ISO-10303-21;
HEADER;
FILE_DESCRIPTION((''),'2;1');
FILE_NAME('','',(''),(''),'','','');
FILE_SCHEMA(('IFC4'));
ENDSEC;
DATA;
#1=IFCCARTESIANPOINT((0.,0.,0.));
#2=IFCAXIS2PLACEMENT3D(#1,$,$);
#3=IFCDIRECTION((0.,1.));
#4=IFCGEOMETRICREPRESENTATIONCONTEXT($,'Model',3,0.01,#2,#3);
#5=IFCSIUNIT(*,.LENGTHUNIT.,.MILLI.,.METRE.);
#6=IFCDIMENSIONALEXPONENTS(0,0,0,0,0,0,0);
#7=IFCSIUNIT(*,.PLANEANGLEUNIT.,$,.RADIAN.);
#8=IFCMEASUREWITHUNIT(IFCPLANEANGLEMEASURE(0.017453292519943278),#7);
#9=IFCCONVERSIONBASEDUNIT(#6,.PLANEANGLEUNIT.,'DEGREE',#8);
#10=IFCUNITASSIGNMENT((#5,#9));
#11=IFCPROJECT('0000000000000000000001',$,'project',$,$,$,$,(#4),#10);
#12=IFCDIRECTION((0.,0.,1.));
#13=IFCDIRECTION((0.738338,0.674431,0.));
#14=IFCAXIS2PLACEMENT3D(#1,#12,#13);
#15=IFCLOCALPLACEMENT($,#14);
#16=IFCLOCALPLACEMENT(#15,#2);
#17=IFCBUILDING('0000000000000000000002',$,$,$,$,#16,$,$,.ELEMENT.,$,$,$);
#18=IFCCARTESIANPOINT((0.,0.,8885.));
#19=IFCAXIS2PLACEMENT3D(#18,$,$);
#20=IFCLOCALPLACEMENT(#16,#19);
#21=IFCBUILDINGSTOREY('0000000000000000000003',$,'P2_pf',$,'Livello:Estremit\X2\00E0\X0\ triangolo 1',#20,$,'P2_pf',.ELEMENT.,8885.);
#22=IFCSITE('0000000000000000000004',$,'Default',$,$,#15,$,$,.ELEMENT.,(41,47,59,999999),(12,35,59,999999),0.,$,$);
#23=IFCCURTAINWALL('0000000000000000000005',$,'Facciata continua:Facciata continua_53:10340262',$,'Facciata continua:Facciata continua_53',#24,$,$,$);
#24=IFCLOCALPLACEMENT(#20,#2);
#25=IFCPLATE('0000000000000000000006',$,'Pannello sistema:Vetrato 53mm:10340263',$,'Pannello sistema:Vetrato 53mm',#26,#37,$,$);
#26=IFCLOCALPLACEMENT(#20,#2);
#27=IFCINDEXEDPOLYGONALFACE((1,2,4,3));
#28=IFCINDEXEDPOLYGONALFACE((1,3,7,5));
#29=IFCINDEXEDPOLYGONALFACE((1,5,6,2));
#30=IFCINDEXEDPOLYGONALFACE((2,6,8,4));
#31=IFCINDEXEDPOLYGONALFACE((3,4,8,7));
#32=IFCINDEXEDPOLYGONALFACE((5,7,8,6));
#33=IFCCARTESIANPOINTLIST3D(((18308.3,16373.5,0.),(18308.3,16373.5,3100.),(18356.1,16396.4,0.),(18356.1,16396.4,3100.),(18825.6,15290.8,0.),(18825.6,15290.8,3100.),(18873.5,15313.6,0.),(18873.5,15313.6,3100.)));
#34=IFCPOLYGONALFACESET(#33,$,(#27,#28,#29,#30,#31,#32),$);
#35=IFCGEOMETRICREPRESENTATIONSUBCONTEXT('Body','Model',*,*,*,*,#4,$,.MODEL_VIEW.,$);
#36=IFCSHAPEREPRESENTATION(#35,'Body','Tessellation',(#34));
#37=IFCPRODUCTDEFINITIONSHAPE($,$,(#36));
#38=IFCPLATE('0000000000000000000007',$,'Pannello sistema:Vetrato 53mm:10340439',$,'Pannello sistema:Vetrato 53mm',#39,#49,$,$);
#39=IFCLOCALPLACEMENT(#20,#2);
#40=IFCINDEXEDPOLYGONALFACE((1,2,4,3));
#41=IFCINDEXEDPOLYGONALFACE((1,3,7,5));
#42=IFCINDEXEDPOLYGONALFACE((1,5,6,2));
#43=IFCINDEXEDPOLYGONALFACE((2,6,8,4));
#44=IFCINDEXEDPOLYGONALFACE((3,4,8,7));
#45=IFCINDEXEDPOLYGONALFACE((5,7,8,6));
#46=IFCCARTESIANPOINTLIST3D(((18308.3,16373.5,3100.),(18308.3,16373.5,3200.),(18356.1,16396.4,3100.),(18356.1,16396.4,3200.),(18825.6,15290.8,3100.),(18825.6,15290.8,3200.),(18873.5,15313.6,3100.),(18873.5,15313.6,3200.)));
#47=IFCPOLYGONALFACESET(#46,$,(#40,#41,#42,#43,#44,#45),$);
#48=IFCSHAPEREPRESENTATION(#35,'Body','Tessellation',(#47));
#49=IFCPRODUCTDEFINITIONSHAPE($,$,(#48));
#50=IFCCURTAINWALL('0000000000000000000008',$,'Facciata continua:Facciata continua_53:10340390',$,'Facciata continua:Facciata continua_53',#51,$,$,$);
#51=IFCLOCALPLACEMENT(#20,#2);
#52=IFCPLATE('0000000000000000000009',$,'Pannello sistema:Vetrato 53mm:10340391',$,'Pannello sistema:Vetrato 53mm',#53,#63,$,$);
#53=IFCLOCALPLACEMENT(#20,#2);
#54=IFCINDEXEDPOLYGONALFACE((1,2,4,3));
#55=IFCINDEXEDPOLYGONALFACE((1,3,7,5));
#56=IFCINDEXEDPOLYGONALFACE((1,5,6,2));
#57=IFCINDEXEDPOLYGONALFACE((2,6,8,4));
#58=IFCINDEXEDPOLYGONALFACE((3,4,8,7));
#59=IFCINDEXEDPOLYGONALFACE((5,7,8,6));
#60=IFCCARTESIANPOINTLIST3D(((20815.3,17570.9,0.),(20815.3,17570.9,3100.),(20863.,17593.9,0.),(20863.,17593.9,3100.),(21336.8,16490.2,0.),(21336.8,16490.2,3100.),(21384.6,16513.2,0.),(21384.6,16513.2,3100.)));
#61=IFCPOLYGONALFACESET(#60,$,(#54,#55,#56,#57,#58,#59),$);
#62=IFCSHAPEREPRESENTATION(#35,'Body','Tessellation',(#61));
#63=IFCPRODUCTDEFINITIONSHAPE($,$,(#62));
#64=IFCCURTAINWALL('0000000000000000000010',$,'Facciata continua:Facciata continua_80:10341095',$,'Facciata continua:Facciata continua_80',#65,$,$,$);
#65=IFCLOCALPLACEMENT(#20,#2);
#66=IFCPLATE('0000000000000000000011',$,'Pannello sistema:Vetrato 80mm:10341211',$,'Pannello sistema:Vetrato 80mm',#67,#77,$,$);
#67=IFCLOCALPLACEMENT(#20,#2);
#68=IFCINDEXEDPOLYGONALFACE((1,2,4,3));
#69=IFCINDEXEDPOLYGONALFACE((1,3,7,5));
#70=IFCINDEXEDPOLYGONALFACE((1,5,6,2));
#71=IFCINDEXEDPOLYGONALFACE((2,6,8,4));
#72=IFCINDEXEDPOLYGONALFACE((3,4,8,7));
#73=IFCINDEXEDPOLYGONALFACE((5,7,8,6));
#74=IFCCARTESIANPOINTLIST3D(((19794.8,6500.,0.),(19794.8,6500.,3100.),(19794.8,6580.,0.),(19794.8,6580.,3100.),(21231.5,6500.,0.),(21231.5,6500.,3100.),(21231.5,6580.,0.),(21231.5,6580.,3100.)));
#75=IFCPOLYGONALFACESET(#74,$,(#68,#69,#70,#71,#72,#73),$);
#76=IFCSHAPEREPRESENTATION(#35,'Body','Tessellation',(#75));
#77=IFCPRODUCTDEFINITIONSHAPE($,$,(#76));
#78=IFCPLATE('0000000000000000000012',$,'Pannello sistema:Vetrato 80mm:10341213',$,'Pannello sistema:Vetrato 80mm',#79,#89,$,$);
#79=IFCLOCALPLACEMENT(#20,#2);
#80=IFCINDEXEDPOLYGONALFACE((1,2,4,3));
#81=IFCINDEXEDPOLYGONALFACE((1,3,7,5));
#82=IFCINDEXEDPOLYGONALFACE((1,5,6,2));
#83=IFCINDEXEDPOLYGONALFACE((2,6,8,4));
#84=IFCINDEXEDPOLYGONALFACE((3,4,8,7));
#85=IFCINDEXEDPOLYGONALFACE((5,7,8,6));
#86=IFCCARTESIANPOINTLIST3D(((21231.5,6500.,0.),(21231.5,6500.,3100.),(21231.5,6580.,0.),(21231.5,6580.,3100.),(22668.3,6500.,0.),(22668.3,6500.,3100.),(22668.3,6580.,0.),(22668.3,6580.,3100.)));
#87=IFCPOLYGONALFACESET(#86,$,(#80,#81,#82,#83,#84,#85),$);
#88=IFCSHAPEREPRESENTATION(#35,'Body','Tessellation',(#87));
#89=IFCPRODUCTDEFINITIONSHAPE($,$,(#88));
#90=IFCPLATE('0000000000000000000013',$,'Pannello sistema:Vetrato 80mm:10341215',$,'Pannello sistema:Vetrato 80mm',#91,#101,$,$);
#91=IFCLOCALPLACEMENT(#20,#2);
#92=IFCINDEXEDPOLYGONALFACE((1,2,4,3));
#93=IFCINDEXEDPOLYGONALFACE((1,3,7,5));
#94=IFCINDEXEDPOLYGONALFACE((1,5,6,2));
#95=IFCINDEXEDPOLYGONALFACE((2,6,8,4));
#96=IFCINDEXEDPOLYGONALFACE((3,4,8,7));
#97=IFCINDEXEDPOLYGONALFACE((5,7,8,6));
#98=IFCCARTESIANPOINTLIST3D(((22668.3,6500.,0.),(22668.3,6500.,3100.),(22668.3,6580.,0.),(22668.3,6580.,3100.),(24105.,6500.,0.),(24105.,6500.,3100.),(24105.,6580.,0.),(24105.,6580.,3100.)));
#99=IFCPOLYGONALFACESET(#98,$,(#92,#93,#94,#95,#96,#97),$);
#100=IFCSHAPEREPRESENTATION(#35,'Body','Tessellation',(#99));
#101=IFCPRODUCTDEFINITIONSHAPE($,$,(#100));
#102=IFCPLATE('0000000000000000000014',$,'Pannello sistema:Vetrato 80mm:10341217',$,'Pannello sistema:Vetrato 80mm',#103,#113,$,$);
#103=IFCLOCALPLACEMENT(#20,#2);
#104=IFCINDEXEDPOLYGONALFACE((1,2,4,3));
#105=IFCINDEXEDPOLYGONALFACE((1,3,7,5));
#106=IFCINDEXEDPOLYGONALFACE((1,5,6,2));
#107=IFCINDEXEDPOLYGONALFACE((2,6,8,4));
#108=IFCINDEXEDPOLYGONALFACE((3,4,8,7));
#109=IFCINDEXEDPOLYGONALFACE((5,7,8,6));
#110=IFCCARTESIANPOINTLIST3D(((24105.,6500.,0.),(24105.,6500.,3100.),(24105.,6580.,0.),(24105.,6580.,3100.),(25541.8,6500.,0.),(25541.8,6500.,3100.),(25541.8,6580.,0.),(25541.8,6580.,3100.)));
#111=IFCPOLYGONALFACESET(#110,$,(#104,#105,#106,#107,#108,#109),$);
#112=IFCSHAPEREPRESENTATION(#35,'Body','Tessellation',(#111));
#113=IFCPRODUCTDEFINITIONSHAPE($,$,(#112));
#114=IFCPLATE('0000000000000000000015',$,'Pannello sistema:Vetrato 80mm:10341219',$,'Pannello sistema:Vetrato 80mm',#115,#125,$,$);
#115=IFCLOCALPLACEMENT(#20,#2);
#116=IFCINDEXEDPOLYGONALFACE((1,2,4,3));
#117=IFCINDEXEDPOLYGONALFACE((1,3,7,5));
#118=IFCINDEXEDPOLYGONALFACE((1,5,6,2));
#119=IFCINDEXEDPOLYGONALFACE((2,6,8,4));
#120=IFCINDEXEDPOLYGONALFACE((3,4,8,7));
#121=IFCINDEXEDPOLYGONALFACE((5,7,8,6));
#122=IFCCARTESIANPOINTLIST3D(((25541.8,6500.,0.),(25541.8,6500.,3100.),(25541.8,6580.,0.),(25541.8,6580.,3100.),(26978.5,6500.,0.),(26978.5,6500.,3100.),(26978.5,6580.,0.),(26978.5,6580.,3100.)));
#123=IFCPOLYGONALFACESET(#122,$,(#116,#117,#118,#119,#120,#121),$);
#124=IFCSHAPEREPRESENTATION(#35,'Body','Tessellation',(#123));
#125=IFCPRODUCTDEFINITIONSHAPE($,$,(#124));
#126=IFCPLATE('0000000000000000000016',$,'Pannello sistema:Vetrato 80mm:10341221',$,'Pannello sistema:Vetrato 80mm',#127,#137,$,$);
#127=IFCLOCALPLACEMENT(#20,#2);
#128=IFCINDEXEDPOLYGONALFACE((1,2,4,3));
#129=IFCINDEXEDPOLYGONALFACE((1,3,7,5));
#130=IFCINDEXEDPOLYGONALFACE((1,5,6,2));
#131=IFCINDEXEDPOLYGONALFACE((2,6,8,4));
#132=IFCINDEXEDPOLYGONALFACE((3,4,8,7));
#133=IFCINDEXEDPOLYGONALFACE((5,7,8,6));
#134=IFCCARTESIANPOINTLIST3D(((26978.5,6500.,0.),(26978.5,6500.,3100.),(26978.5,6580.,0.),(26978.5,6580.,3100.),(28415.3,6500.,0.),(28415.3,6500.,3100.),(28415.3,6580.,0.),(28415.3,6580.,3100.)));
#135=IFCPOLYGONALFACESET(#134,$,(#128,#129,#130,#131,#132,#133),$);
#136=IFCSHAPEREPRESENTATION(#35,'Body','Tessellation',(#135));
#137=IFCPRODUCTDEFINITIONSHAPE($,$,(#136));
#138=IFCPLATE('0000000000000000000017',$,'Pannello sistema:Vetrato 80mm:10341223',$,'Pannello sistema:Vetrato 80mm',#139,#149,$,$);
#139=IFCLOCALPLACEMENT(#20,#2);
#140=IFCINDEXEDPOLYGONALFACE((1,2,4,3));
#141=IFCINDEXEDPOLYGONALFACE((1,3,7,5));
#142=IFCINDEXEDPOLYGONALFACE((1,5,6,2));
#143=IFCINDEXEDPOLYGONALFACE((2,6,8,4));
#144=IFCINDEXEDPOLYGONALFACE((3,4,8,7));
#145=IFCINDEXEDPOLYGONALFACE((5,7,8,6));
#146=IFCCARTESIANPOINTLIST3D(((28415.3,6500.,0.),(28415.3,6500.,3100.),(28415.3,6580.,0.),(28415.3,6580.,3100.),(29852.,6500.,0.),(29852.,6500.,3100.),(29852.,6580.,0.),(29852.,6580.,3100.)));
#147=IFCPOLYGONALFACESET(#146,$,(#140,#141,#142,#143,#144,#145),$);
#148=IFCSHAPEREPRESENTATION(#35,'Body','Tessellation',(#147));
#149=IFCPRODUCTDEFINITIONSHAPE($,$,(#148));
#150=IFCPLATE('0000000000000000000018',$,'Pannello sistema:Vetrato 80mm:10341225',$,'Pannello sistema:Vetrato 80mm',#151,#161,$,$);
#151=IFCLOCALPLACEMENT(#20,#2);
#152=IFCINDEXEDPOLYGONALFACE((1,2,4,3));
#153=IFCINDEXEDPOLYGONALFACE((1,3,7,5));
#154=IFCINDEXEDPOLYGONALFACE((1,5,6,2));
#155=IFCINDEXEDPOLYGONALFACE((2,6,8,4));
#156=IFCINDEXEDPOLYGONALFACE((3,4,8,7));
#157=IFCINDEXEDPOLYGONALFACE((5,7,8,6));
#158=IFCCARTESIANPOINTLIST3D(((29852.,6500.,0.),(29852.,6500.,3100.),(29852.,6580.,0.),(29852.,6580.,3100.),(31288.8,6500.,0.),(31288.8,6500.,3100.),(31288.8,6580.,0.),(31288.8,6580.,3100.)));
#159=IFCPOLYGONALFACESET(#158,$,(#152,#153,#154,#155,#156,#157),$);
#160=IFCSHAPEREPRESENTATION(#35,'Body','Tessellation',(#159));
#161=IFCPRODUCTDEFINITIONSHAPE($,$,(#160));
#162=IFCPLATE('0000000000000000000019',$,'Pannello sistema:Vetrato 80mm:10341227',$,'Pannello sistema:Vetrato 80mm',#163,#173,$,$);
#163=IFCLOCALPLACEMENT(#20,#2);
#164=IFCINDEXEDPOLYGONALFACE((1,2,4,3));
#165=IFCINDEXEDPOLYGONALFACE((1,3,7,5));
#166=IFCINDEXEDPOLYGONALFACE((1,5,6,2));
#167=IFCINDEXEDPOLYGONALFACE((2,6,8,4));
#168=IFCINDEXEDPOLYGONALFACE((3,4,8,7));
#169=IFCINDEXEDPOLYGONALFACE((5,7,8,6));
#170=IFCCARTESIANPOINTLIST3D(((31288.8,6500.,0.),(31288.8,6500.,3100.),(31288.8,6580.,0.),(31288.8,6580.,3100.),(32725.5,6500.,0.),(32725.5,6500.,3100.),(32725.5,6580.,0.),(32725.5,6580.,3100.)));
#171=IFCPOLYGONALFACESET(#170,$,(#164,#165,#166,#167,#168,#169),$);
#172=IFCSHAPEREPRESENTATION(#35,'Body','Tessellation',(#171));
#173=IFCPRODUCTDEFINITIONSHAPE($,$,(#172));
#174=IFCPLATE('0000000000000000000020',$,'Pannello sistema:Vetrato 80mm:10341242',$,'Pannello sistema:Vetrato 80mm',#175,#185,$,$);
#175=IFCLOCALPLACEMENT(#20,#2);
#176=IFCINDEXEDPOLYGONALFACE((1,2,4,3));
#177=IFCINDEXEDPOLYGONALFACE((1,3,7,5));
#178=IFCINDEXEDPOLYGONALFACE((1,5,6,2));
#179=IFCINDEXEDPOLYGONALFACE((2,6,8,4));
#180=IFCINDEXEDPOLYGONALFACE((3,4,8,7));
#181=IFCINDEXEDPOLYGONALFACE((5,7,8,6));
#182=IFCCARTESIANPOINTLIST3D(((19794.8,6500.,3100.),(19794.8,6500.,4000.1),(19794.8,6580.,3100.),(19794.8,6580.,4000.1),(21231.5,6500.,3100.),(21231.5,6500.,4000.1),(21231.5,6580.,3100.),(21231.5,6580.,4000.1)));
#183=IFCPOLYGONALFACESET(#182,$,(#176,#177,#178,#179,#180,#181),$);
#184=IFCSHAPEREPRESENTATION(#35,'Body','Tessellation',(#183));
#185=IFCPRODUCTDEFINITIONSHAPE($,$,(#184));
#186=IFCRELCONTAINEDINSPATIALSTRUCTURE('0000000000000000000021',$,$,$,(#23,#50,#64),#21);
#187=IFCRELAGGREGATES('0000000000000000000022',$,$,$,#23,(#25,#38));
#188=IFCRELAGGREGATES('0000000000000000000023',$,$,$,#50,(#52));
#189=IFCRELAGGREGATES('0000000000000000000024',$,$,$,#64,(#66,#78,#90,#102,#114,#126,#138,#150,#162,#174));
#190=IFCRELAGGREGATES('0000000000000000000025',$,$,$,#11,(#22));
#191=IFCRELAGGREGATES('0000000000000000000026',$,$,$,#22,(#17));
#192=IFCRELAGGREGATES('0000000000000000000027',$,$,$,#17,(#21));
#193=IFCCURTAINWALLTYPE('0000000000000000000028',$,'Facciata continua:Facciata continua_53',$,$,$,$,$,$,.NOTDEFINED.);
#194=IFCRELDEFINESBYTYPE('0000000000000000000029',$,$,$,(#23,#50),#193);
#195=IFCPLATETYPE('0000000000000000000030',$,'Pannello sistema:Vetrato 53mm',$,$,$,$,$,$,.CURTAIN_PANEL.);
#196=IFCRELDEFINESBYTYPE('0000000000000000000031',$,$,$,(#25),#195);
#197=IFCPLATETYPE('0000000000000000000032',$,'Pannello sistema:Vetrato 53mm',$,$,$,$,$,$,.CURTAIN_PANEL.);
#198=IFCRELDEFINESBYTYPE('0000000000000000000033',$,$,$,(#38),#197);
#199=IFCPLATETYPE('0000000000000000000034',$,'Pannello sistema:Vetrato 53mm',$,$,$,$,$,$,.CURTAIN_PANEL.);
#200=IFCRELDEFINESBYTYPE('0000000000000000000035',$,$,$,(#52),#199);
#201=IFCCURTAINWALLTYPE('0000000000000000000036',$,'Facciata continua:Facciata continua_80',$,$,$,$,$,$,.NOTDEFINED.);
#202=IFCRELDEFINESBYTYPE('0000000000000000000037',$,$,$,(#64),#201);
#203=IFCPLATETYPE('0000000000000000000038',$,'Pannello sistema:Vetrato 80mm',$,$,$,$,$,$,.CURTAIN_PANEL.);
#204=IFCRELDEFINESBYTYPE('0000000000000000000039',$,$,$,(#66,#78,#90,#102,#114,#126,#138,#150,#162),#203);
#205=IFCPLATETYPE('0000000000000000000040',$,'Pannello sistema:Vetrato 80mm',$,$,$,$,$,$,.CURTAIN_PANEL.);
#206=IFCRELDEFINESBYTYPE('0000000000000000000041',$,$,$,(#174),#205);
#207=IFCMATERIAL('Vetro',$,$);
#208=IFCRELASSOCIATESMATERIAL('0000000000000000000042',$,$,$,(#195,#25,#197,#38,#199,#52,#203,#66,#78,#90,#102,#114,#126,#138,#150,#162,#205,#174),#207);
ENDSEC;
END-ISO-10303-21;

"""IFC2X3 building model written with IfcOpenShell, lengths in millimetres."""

from ifc_helpers import new_model, entity, si_unit, converted_unit, direction, frame, frame_2d, origin, origin_2d_with_axis, place, context, subcontext, project, spatial, rectangle, extrude, source, transform, mapped, material, type_object, type_shapes, element, aggregate, save


model = new_model("IFC2X3")

# Units and contexts
model_context = context("Model", 3, precision=0.01, world=origin(), true_north=direction((0.0, 1.0)))
body_context = subcontext(model_context, "Body", "Model", "MODEL_VIEW")
ifc_project = project(units=[si_unit("LENGTHUNIT", "METRE", prefix="MILLI"), converted_unit("PLANEANGLEUNIT", "DEGREE", entity("IfcPlaneAngleMeasure", 0.017453292519943278), si_unit("PLANEANGLEUNIT", "RADIAN"), dimensions=[0, 0, 0, 0, 0, 0, 0])], contexts=[model_context])

# Site, building, storey
site_placement = place(None, frame((0.0, 0.0, 0.0), z_axis=(0.0, 0.0, 1.0), x_axis=(0.738338, 0.674431, 0.0)))
site = spatial("IfcSite", under=ifc_project, at=site_placement, Name="Default", CompositionType="ELEMENT", RefLatitude=(41, 47, 59, 999999), RefLongitude=(12, 35, 59, 999999), RefElevation=0.0)
building_placement = place(site_placement, origin())
building = spatial("IfcBuilding", under=site, at=building_placement, CompositionType="ELEMENT")
storey_placement = place(building_placement, frame((0.0, 0.0, 8885.0)))
storey = spatial("IfcBuildingStorey", under=building, at=storey_placement, Name="P2_pf", ObjectType="Livello:Estremità triangolo 1", LongName="P2_pf", CompositionType="ELEMENT", Elevation=8885.0)

# Curtain wall, plates
curtain_wall_type_1 = type_object("IfcCurtainWallType", Name="Facciata continua:Facciata continua_53", PredefinedType="NOTDEFINED")
curtain_wall_1_placement = place(storey_placement, frame((0.0, 0.0, -8885.0)))
curtain_wall_1 = element("IfcCurtainWall", 1, at=curtain_wall_1_placement, inside=storey, type_object=curtain_wall_type_1, Name="Facciata continua:Facciata continua_53:10340262", ObjectType="Facciata continua:Facciata continua_53")
ifc_material_1 = material(Name="Vetro")
plate_type_1 = type_object("IfcPlateType", Name="Pannello sistema:Vetrato 53mm", PredefinedType="CURTAIN_PANEL", material=ifc_material_1)
shared_shape_1 = source(origin(), body_context, "Body", "SweptSolid", [
    extrude(rectangle(XDim=53.0, YDim=1200.0, at=frame_2d((0.0, 0.0), x_axis=(1.0, 0.0))), frame((0.0, -26.5, 0.0), z_axis=(0.0, 0.0, 1.0), x_axis=(0.0, 1.0, 0.0)), (0.0, 0.0, 1.0), 3100.0),
])
type_shapes(plate_type_1, [shared_shape_1])
plate_1_placement = place(curtain_wall_1_placement, frame((18567.0, 15832.1, 8885.0), z_axis=(0.0, 0.0, 1.0), x_axis=(-0.431118, 0.902296, 0.0)))
plate_1 = element("IfcPlate", 2, at=plate_1_placement, type_object=plate_type_1, material=ifc_material_1, Name="Pannello sistema:Vetrato 53mm:10340263", ObjectType="Pannello sistema:Vetrato 53mm", context=body_context, shape_type="MappedRepresentation", body=[
    mapped(shared_shape_1, transform((0.0, 0.0, 0.0), scale=1.0)),
])
plate_type_2 = type_object("IfcPlateType", Name="Pannello sistema:Vetrato 53mm", PredefinedType="CURTAIN_PANEL", material=ifc_material_1)
shared_shape_2 = source(origin(), body_context, "Body", "SweptSolid", [
    extrude(rectangle(XDim=53.0, YDim=1200.0, at=frame_2d((0.0, 0.0), x_axis=(1.0, 0.0))), frame((0.0, -26.5, 0.0), z_axis=(0.0, 0.0, 1.0), x_axis=(0.0, 1.0, 0.0)), (0.0, 0.0, 1.0), 100.0),
])
type_shapes(plate_type_2, [shared_shape_2])
plate_2_placement = place(curtain_wall_1_placement, frame((18567.0, 15832.1, 11985.0), z_axis=(0.0, 0.0, 1.0), x_axis=(-0.431118, 0.902296, 0.0)))
plate_2 = element("IfcPlate", 3, at=plate_2_placement, type_object=plate_type_2, material=ifc_material_1, Name="Pannello sistema:Vetrato 53mm:10340439", ObjectType="Pannello sistema:Vetrato 53mm", context=body_context, shape_type="MappedRepresentation", body=[
    mapped(shared_shape_2, transform((0.0, 0.0, 0.0), scale=1.0)),
])
aggregate(curtain_wall_1, [plate_1, plate_2])

# Curtain wall, plate
curtain_wall_2_placement = place(storey_placement, frame((0.0, 0.0, -8885.0)))
curtain_wall_2 = element("IfcCurtainWall", 4, at=curtain_wall_2_placement, inside=storey, type_object=curtain_wall_type_1, Name="Facciata continua:Facciata continua_53:10340390", ObjectType="Facciata continua:Facciata continua_53")
plate_type_3 = type_object("IfcPlateType", Name="Pannello sistema:Vetrato 53mm", PredefinedType="CURTAIN_PANEL", material=ifc_material_1)
shared_shape_3 = source(origin(), body_context, "Body", "SweptSolid", [
    extrude(rectangle(XDim=53.0, YDim=1200.0, at=frame_2d((0.0, 0.0), x_axis=(1.0, 0.0))), frame((0.0, -26.5, 0.0), z_axis=(0.0, 0.0, 1.0), x_axis=(0.0, 1.0, 0.0)), (0.0, 0.0, 1.0), 3100.0),
])
type_shapes(plate_type_3, [shared_shape_3])
plate_3_placement = place(curtain_wall_2_placement, frame((21076.1, 17030.5, 8885.0), z_axis=(0.0, 0.0, 1.0), x_axis=(-0.434619, 0.900614, 0.0)))
plate_3 = element("IfcPlate", 5, at=plate_3_placement, type_object=plate_type_3, material=ifc_material_1, Name="Pannello sistema:Vetrato 53mm:10340391", ObjectType="Pannello sistema:Vetrato 53mm", context=body_context, shape_type="MappedRepresentation", body=[
    mapped(shared_shape_3, transform((0.0, 0.0, 0.0), scale=1.0)),
])
aggregate(curtain_wall_2, [plate_3])

# Curtain wall, plates
curtain_wall_type_2 = type_object("IfcCurtainWallType", Name="Facciata continua:Facciata continua_80", PredefinedType="NOTDEFINED")
curtain_wall_3_placement = place(storey_placement, frame((0.0, 0.0, -8885.0)))
curtain_wall_3 = element("IfcCurtainWall", 6, at=curtain_wall_3_placement, inside=storey, type_object=curtain_wall_type_2, Name="Facciata continua:Facciata continua_80:10341095", ObjectType="Facciata continua:Facciata continua_80")
plate_type_4 = type_object("IfcPlateType", Name="Pannello sistema:Vetrato 80mm", PredefinedType="CURTAIN_PANEL", material=ifc_material_1)
shared_shape_4 = source(origin(), body_context, "Body", "SweptSolid", [
    extrude(rectangle(XDim=80.0, YDim=1436.8, at=origin_2d_with_axis()), frame((0.0, -40.0, 0.0), z_axis=(0.0, 0.0, 1.0), x_axis=(0.0, 1.0, 0.0)), (0.0, 0.0, 1.0), 3100.0),
])
type_shapes(plate_type_4, [shared_shape_4])
plate_4_placement = place(curtain_wall_3_placement, frame((20513.1, 6580.0, 8885.0)))
plate_4 = element("IfcPlate", 7, at=plate_4_placement, type_object=plate_type_4, material=ifc_material_1, Name="Pannello sistema:Vetrato 80mm:10341211", ObjectType="Pannello sistema:Vetrato 80mm", context=body_context, shape_type="MappedRepresentation", body=[
    mapped(shared_shape_4, transform((0.0, 0.0, 0.0), scale=1.0)),
])
plate_5_placement = place(curtain_wall_3_placement, frame((21949.9, 6580.0, 8885.0)))
plate_5 = element("IfcPlate", 8, at=plate_5_placement, type_object=plate_type_4, material=ifc_material_1, Name="Pannello sistema:Vetrato 80mm:10341213", ObjectType="Pannello sistema:Vetrato 80mm", context=body_context, shape_type="MappedRepresentation", body=[
    mapped(shared_shape_4, transform((0.0, 0.0, 0.0), scale=1.0)),
])
plate_6_placement = place(curtain_wall_3_placement, frame((23386.6, 6580.0, 8885.0)))
plate_6 = element("IfcPlate", 9, at=plate_6_placement, type_object=plate_type_4, material=ifc_material_1, Name="Pannello sistema:Vetrato 80mm:10341215", ObjectType="Pannello sistema:Vetrato 80mm", context=body_context, shape_type="MappedRepresentation", body=[
    mapped(shared_shape_4, transform((0.0, 0.0, 0.0), scale=1.0)),
])
plate_7_placement = place(curtain_wall_3_placement, frame((24823.4, 6580.0, 8885.0)))
plate_7 = element("IfcPlate", 10, at=plate_7_placement, type_object=plate_type_4, material=ifc_material_1, Name="Pannello sistema:Vetrato 80mm:10341217", ObjectType="Pannello sistema:Vetrato 80mm", context=body_context, shape_type="MappedRepresentation", body=[
    mapped(shared_shape_4, transform((0.0, 0.0, 0.0), scale=1.0)),
])
plate_8_placement = place(curtain_wall_3_placement, frame((26260.2, 6580.0, 8885.0)))
plate_8 = element("IfcPlate", 11, at=plate_8_placement, type_object=plate_type_4, material=ifc_material_1, Name="Pannello sistema:Vetrato 80mm:10341219", ObjectType="Pannello sistema:Vetrato 80mm", context=body_context, shape_type="MappedRepresentation", body=[
    mapped(shared_shape_4, transform((0.0, 0.0, 0.0), scale=1.0)),
])
plate_9_placement = place(curtain_wall_3_placement, frame((27696.9, 6580.0, 8885.0)))
plate_9 = element("IfcPlate", 12, at=plate_9_placement, type_object=plate_type_4, material=ifc_material_1, Name="Pannello sistema:Vetrato 80mm:10341221", ObjectType="Pannello sistema:Vetrato 80mm", context=body_context, shape_type="MappedRepresentation", body=[
    mapped(shared_shape_4, transform((0.0, 0.0, 0.0), scale=1.0)),
])
plate_10_placement = place(curtain_wall_3_placement, frame((29133.7, 6580.0, 8885.0)))
plate_10 = element("IfcPlate", 13, at=plate_10_placement, type_object=plate_type_4, material=ifc_material_1, Name="Pannello sistema:Vetrato 80mm:10341223", ObjectType="Pannello sistema:Vetrato 80mm", context=body_context, shape_type="MappedRepresentation", body=[
    mapped(shared_shape_4, transform((0.0, 0.0, 0.0), scale=1.0)),
])
plate_11_placement = place(curtain_wall_3_placement, frame((30570.4, 6580.0, 8885.0)))
plate_11 = element("IfcPlate", 14, at=plate_11_placement, type_object=plate_type_4, material=ifc_material_1, Name="Pannello sistema:Vetrato 80mm:10341225", ObjectType="Pannello sistema:Vetrato 80mm", context=body_context, shape_type="MappedRepresentation", body=[
    mapped(shared_shape_4, transform((0.0, 0.0, 0.0), scale=1.0)),
])
plate_12_placement = place(curtain_wall_3_placement, frame((32007.2, 6580.0, 8885.0)))
plate_12 = element("IfcPlate", 15, at=plate_12_placement, type_object=plate_type_4, material=ifc_material_1, Name="Pannello sistema:Vetrato 80mm:10341227", ObjectType="Pannello sistema:Vetrato 80mm", context=body_context, shape_type="MappedRepresentation", body=[
    mapped(shared_shape_4, transform((0.0, 0.0, 0.0), scale=1.0)),
])
plate_type_5 = type_object("IfcPlateType", Name="Pannello sistema:Vetrato 80mm", PredefinedType="CURTAIN_PANEL", material=ifc_material_1)
shared_shape_5 = source(origin(), body_context, "Body", "SweptSolid", [
    extrude(rectangle(XDim=80.0, YDim=1436.8, at=origin_2d_with_axis()), frame((0.0, -40.0, 0.0), z_axis=(0.0, 0.0, 1.0), x_axis=(0.0, 1.0, 0.0)), (0.0, 0.0, 1.0), 900.1),
])
type_shapes(plate_type_5, [shared_shape_5])
plate_13_placement = place(curtain_wall_3_placement, frame((20513.1, 6580.0, 11985.0)))
plate_13 = element("IfcPlate", 16, at=plate_13_placement, type_object=plate_type_5, material=ifc_material_1, Name="Pannello sistema:Vetrato 80mm:10341242", ObjectType="Pannello sistema:Vetrato 80mm", context=body_context, shape_type="MappedRepresentation", body=[
    mapped(shared_shape_5, transform((0.0, 0.0, 0.0), scale=1.0)),
])
aggregate(curtain_wall_3, [plate_4, plate_5, plate_6, plate_7, plate_8, plate_9, plate_10, plate_11, plate_12, plate_13])

save(model, "model.ifc")
